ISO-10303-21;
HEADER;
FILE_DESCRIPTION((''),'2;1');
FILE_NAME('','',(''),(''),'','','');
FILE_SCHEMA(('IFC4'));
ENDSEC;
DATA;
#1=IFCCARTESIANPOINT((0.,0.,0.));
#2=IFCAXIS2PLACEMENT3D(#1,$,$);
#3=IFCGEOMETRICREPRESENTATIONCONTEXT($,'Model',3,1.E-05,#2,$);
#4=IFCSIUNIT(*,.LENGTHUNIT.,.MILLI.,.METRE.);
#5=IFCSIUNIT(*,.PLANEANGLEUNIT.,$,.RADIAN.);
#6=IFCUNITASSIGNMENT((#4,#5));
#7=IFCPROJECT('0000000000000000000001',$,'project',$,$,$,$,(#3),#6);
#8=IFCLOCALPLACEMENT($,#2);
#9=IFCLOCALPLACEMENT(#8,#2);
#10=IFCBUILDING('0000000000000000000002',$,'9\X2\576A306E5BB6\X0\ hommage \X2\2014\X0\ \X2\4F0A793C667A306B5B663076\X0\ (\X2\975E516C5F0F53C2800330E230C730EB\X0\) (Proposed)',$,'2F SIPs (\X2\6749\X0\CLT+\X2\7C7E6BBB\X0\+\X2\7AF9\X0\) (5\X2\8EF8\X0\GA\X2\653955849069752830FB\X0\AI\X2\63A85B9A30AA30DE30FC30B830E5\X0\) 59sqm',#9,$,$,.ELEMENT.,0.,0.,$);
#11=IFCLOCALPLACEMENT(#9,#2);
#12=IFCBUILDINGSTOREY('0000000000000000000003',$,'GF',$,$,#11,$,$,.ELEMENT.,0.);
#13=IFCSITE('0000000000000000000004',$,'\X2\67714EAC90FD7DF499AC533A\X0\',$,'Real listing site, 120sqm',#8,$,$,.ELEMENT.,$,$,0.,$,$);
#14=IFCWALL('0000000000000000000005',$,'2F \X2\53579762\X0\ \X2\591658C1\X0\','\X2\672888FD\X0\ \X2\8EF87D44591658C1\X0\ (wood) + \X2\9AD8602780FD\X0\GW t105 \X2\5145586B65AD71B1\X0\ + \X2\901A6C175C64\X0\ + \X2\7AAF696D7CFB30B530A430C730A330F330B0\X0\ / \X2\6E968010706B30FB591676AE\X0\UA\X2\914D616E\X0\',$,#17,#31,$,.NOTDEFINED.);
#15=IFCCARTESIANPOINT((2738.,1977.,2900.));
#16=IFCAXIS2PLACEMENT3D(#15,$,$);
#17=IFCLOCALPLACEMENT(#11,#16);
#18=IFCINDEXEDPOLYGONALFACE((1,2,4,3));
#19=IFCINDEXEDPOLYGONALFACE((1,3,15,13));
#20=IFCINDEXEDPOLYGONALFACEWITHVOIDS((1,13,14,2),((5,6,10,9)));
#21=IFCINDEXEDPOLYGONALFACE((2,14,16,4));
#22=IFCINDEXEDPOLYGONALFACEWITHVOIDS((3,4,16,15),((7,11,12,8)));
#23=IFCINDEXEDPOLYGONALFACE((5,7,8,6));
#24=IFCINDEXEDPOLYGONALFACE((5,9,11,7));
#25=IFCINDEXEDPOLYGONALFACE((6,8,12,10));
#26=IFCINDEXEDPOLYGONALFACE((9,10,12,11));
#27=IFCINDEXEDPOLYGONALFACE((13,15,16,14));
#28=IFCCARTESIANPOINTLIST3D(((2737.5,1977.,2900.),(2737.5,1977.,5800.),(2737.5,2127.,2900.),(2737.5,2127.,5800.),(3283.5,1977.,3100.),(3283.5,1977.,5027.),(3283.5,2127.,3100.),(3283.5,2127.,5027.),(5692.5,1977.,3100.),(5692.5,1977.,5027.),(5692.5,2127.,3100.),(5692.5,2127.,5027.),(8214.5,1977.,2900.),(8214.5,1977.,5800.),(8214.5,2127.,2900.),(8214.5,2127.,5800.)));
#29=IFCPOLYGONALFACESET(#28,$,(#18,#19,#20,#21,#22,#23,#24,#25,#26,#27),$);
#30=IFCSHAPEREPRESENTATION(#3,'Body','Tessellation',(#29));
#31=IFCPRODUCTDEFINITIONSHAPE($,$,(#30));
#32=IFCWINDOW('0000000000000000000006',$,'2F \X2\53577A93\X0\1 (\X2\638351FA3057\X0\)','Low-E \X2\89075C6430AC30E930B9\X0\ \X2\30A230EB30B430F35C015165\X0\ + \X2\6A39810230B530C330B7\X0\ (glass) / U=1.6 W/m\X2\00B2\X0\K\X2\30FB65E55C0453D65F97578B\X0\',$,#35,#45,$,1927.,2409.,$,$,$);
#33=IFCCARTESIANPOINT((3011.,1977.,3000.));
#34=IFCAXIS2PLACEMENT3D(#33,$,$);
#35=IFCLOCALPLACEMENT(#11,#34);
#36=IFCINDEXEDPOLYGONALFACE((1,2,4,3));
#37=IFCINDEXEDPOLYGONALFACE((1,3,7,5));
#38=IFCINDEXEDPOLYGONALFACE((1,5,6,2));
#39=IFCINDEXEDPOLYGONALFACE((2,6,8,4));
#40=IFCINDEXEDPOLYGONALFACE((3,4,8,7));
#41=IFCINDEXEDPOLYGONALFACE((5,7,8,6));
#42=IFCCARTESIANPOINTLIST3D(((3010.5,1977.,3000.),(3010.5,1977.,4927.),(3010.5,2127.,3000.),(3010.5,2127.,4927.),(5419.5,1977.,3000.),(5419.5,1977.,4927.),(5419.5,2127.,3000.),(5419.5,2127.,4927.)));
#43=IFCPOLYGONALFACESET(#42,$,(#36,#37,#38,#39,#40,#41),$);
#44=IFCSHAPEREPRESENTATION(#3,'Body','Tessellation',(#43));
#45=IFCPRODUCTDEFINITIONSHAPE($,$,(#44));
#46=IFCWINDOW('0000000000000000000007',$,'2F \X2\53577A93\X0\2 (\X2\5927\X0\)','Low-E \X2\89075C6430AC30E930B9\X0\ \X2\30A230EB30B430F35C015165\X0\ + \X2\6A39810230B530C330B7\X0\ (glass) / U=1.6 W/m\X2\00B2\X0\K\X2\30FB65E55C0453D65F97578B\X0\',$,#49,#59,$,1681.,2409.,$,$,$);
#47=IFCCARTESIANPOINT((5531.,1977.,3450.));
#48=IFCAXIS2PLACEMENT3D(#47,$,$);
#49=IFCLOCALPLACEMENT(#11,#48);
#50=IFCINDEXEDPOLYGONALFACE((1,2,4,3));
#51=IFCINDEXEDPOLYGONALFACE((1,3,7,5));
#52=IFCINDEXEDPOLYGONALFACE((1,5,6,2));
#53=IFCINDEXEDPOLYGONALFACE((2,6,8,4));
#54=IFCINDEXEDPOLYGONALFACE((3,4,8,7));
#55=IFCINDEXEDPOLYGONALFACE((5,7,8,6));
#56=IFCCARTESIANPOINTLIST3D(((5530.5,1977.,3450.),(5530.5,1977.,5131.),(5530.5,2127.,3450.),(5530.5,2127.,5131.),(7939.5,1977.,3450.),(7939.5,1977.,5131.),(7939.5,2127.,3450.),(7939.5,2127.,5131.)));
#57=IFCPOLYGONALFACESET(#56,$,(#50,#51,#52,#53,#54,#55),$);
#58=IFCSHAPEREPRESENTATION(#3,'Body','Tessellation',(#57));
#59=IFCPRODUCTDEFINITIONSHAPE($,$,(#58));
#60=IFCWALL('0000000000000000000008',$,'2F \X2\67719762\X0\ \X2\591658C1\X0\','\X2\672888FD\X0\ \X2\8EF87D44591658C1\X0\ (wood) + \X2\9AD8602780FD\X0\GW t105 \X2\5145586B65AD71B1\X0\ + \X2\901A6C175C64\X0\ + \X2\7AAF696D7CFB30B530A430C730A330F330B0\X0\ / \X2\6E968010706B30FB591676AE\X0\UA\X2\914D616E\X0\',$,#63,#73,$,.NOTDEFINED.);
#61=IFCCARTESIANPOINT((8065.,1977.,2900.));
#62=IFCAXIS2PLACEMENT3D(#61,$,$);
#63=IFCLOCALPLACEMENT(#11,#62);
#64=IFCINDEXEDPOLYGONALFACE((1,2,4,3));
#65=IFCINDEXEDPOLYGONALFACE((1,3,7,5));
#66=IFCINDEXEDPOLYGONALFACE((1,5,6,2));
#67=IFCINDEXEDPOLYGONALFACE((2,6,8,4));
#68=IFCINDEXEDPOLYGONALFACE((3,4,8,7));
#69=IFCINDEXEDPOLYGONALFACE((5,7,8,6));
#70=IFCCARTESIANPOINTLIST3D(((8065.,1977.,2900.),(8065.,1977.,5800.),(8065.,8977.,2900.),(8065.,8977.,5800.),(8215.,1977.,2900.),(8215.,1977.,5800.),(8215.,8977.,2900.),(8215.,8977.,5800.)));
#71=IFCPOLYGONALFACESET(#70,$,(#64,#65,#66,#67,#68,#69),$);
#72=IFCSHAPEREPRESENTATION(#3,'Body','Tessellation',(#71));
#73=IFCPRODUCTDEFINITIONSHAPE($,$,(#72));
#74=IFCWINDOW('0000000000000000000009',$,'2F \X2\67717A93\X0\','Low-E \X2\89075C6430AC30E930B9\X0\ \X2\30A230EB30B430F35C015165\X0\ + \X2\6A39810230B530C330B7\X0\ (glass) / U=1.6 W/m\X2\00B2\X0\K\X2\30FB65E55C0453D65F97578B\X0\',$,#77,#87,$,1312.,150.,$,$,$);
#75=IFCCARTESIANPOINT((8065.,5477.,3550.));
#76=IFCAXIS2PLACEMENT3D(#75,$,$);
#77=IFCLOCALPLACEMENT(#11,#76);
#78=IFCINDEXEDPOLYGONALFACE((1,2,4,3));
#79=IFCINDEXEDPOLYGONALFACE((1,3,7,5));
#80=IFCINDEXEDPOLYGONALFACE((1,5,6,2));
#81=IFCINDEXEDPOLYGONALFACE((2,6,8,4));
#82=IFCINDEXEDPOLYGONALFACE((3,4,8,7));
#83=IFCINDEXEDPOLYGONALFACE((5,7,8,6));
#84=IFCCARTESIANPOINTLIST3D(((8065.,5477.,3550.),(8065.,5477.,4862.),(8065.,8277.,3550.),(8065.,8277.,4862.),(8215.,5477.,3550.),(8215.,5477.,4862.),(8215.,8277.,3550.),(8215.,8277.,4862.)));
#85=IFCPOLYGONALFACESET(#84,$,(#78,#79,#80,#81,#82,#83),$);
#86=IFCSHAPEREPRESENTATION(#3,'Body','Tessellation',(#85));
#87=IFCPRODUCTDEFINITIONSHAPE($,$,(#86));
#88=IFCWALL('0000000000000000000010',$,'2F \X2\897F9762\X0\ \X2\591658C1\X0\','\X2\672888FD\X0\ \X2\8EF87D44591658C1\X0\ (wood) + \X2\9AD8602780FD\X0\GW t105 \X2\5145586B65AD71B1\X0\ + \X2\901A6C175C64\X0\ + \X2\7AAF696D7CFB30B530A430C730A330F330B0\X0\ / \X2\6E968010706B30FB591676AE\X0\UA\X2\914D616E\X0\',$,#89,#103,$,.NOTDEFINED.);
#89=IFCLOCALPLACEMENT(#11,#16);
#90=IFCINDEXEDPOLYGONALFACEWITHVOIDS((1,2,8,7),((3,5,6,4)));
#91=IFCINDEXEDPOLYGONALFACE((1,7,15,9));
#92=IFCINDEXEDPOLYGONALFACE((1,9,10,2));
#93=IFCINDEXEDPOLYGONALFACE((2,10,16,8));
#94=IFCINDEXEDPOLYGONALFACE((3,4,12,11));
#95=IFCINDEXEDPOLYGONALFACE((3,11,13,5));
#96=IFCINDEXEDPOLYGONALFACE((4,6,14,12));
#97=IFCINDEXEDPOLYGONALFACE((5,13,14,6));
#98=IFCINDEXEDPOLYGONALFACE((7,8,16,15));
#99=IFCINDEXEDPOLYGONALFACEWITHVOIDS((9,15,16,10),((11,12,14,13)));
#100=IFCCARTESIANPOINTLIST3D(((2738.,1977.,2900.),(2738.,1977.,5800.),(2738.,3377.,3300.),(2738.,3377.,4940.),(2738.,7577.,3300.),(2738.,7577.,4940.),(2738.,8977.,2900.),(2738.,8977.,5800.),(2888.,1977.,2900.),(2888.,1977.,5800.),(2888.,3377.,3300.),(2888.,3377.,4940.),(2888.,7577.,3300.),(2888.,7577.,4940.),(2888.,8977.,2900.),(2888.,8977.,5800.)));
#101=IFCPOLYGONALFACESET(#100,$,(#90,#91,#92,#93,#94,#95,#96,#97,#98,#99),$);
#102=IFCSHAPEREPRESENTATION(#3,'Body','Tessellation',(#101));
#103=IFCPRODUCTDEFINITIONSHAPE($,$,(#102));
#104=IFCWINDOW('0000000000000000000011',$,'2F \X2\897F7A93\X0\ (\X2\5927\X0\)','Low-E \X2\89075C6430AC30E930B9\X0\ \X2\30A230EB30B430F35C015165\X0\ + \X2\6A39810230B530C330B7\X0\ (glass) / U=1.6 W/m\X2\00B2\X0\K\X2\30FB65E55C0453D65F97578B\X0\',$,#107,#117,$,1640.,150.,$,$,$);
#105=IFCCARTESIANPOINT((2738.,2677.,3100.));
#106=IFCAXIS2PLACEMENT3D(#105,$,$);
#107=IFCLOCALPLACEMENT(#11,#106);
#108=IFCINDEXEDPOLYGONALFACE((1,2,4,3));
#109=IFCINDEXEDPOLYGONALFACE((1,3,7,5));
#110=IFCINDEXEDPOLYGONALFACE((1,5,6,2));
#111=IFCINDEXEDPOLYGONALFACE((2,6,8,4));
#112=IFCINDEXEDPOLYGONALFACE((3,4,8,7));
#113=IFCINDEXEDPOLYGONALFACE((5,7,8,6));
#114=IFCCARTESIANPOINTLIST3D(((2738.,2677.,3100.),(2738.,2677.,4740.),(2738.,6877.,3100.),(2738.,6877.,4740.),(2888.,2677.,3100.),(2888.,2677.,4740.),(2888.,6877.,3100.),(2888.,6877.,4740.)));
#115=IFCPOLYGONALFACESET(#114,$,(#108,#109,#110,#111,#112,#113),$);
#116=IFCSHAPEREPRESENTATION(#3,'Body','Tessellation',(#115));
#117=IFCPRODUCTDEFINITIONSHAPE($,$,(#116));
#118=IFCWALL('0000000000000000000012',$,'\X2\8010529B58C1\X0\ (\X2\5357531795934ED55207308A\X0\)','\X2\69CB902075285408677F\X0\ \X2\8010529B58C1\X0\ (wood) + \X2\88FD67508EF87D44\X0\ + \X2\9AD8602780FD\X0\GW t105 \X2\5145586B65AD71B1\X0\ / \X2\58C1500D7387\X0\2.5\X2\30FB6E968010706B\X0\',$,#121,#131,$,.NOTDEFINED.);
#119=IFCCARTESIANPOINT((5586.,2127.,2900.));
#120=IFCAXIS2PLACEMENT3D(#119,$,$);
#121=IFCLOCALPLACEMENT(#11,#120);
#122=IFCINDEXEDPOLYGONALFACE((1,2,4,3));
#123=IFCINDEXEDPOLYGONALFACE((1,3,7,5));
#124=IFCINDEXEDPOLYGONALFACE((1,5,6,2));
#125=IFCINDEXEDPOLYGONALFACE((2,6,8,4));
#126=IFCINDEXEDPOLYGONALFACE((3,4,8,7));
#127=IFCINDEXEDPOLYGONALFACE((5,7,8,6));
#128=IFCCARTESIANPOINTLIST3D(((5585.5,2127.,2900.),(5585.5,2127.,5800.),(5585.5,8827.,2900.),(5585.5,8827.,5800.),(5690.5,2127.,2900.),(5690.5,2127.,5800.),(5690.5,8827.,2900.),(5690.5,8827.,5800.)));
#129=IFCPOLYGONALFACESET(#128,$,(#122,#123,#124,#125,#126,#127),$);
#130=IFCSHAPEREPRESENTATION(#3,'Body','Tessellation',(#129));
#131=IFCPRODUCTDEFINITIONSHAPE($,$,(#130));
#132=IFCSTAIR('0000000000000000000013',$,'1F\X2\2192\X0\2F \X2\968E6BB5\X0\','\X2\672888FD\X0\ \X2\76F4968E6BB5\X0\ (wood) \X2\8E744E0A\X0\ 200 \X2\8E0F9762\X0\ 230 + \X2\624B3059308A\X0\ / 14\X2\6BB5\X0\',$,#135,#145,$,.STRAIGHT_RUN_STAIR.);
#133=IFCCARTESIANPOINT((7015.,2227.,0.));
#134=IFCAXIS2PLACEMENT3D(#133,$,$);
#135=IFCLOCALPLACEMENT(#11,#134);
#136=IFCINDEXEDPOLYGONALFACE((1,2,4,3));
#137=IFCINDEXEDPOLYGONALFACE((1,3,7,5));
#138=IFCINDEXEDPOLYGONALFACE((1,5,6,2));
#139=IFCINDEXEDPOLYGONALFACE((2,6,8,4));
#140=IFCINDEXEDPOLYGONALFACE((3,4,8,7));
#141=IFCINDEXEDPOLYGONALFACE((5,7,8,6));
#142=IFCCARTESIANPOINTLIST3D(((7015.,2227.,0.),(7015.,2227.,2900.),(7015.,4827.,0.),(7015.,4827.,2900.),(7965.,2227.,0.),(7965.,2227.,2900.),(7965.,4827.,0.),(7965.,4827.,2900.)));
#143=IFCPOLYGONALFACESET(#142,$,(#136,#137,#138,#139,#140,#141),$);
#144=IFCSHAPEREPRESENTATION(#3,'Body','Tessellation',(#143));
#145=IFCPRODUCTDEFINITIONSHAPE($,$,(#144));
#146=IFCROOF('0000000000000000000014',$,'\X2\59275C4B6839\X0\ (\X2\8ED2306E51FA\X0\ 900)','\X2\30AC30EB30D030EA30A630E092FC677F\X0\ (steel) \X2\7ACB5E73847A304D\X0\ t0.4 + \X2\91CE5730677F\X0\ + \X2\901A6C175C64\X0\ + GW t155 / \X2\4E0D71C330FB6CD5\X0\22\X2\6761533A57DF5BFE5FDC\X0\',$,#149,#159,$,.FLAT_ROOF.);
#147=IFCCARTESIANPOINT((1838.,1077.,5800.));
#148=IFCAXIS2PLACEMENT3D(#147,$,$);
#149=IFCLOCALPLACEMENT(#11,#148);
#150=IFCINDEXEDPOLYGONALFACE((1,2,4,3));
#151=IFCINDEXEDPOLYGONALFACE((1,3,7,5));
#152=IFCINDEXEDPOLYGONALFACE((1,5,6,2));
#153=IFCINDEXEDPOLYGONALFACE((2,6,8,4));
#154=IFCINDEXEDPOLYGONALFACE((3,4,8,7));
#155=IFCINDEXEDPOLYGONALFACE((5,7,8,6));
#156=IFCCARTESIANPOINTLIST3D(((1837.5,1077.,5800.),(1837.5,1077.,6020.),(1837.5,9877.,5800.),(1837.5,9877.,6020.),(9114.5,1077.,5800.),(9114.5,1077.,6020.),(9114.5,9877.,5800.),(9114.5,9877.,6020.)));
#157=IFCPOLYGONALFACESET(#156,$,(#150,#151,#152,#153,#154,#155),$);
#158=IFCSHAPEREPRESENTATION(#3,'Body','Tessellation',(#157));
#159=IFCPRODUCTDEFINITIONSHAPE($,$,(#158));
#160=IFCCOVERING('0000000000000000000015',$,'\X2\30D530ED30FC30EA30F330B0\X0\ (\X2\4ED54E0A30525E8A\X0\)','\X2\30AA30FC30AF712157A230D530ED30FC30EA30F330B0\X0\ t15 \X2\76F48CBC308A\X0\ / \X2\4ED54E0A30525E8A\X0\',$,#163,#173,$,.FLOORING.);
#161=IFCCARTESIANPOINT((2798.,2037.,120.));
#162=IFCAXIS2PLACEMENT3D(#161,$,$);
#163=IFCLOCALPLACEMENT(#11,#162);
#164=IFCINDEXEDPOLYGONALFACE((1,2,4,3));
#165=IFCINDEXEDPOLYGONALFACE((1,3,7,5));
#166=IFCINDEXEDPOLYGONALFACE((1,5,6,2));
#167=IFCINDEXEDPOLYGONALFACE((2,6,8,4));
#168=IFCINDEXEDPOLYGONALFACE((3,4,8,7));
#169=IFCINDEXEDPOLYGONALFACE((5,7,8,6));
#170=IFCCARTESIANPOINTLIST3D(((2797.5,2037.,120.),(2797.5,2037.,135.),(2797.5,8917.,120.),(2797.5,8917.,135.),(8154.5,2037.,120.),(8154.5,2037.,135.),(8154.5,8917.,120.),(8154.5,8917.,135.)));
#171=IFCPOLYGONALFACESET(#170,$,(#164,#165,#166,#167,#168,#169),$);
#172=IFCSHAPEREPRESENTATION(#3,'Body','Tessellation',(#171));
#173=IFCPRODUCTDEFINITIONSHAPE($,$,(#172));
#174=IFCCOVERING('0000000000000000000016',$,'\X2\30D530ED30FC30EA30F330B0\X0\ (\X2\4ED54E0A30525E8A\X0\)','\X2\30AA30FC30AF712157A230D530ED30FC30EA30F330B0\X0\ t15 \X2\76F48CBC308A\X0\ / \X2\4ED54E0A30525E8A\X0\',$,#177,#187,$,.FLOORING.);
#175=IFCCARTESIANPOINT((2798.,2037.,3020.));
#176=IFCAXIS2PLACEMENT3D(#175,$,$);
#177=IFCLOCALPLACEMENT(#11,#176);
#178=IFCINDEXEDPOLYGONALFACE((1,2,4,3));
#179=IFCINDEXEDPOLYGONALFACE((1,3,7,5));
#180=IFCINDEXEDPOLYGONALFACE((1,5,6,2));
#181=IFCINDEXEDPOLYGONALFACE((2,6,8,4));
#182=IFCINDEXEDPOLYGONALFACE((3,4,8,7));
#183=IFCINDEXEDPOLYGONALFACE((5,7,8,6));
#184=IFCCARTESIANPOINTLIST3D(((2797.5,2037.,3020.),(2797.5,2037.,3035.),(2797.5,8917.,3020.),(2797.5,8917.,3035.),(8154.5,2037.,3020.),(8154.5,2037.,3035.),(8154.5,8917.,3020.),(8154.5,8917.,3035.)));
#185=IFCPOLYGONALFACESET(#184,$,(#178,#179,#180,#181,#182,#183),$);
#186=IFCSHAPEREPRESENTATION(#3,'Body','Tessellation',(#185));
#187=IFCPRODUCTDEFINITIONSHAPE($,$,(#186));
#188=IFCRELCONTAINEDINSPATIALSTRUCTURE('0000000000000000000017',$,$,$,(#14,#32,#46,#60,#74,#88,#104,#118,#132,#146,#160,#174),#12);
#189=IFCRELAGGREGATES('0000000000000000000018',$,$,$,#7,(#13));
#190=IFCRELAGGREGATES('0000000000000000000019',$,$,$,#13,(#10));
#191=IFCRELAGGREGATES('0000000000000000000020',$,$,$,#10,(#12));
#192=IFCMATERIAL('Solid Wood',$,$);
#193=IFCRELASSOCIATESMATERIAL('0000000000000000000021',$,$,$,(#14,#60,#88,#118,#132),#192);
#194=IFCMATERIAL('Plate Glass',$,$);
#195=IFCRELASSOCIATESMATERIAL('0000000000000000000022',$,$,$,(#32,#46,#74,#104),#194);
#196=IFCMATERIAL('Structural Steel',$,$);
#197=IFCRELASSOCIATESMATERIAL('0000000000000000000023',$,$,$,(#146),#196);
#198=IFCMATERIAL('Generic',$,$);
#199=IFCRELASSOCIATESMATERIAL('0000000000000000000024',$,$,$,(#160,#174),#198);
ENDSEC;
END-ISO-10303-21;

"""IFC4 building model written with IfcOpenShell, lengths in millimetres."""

from ifc_helpers import new_model, si_unit, frame, frame_2d, origin, place, context, project, spatial, rectangle, extrude, material, element, fill, save


model = new_model("IFC4")

# Units and contexts
model_context = context("Model", 3, precision=1e-05, world=origin())
ifc_project = project(units=[si_unit("LENGTHUNIT", "METRE", prefix="MILLI"), si_unit("PLANEANGLEUNIT", "RADIAN")], contexts=[model_context])

# Site, building, storey
site_placement = place(None, origin())
site = spatial("IfcSite", under=ifc_project, at=site_placement, Name="東京都練馬区", ObjectType="Real listing site, 120sqm", CompositionType="ELEMENT", RefElevation=0.0)
building_placement = place(site_placement, origin())
building = spatial("IfcBuilding", under=site, at=building_placement, Name="9坪の家 hommage — 伊礼智に学ぶ (非公式参考モデル) (Proposed)", ObjectType="2F SIPs (杉CLT+籾殻+竹) (5軸GA改善適用・AI推定オマージュ) 59sqm", CompositionType="ELEMENT", ElevationOfRefHeight=0.0, ElevationOfTerrain=0.0)
storey_placement = place(building_placement, origin())
storey = spatial("IfcBuildingStorey", under=building, at=storey_placement, Name="GF", CompositionType="ELEMENT", Elevation=0.0)

# Shared definitions
ifc_material_1 = material(Name="Solid Wood")

# Shared definitions
ifc_material_2 = material(Name="Plate Glass")

# Wall, openings, windows
wall_1_placement = place(storey_placement, frame((2738.0, 1977.0, 2900.0)))
wall_1 = element("IfcWall", 1, at=wall_1_placement, inside=storey, material=ifc_material_1, Name="2F 南面 外壁", Description="木製 軸組外壁 (wood) + 高性能GW t105 充填断熱 + 通気層 + 窯業系サイディング / 準耐火・外皮UA配慮", PredefinedType="NOTDEFINED", context=model_context, shape_type="SweptSolid", body=[
    extrude(rectangle(XDim=5477.0, YDim=150.0, at=frame_2d((2738.0, 75.0))), frame((2738.0, 1977.0, 2900.0)), (0.0, 0.0, 1.0), 2900.0),
])
opening_1_placement = place(storey_placement, frame((3011.0, 1977.0, 3000.0)))
opening_1 = element("IfcOpeningElement", 2, at=opening_1_placement, cuts=wall_1, PredefinedType="NOTDEFINED", context=model_context, shape_type="SweptSolid", body=[
    extrude(rectangle(XDim=2409.0, YDim=150.0, at=frame_2d((1204.0, 75.0))), frame((3011.0, 1977.0, 3000.0)), (0.0, 0.0, 1.0), 1927.0),
])
opening_2_placement = place(storey_placement, frame((5531.0, 1977.0, 3450.0)))
opening_2 = element("IfcOpeningElement", 3, at=opening_2_placement, cuts=wall_1, PredefinedType="NOTDEFINED", context=model_context, shape_type="SweptSolid", body=[
    extrude(rectangle(XDim=2409.0, YDim=150.0, at=frame_2d((1204.0, 75.0))), frame((5531.0, 1977.0, 3450.0)), (0.0, 0.0, 1.0), 1681.0),
])
window_1_placement = place(storey_placement, frame((3011.0, 1977.0, 3000.0)))
window_1 = element("IfcWindow", 4, at=window_1_placement, inside=storey, material=ifc_material_2, Name="2F 南窓1 (掃出し)", Description="Low-E 複層ガラス アルゴン封入 + 樹脂サッシ (glass) / U=1.6 W/m²K・日射取得型", OverallHeight=1927.0, OverallWidth=2409.0, context=model_context, shape_type="SweptSolid", body=[
    extrude(rectangle(XDim=2409.0, YDim=150.0, at=frame_2d((1204.0, 75.0))), frame((3011.0, 1977.0, 3000.0)), (0.0, 0.0, 1.0), 1927.0),
])
fill(opening_1, window_1)
window_2_placement = place(storey_placement, frame((5531.0, 1977.0, 3450.0)))
window_2 = element("IfcWindow", 5, at=window_2_placement, inside=storey, material=ifc_material_2, Name="2F 南窓2 (大)", Description="Low-E 複層ガラス アルゴン封入 + 樹脂サッシ (glass) / U=1.6 W/m²K・日射取得型", OverallHeight=1681.0, OverallWidth=2409.0, context=model_context, shape_type="SweptSolid", body=[
    extrude(rectangle(XDim=2409.0, YDim=150.0, at=frame_2d((1204.0, 75.0))), frame((5531.0, 1977.0, 3450.0)), (0.0, 0.0, 1.0), 1681.0),
])
fill(opening_2, window_2)

# Walls, openings, windows
wall_2_placement = place(storey_placement, frame((8065.0, 1977.0, 2900.0)))
wall_2 = element("IfcWall", 6, at=wall_2_placement, inside=storey, material=ifc_material_1, Name="2F 東面 外壁", Description="木製 軸組外壁 (wood) + 高性能GW t105 充填断熱 + 通気層 + 窯業系サイディング / 準耐火・外皮UA配慮", PredefinedType="NOTDEFINED", context=model_context, shape_type="SweptSolid", body=[
    extrude(rectangle(XDim=150.0, YDim=7000.0, at=frame_2d((75.0, 3500.0))), frame((8065.0, 1977.0, 2900.0)), (0.0, 0.0, 1.0), 2900.0),
])
opening_3_placement = place(storey_placement, frame((8065.0, 5477.0, 3550.0)))
opening_3 = element("IfcOpeningElement", 7, at=opening_3_placement, cuts=wall_2, PredefinedType="NOTDEFINED", context=model_context, shape_type="SweptSolid", body=[
    extrude(rectangle(XDim=150.0, YDim=2800.0, at=frame_2d((75.0, 1400.0))), frame((8065.0, 5477.0, 3550.0)), (0.0, 0.0, 1.0), 1312.0),
])
window_3_placement = place(storey_placement, frame((8065.0, 5477.0, 3550.0)))
window_3 = element("IfcWindow", 8, at=window_3_placement, inside=storey, material=ifc_material_2, Name="2F 東窓", Description="Low-E 複層ガラス アルゴン封入 + 樹脂サッシ (glass) / U=1.6 W/m²K・日射取得型", OverallHeight=1312.0, OverallWidth=150.0, context=model_context, shape_type="SweptSolid", body=[
    extrude(rectangle(XDim=150.0, YDim=2800.0, at=frame_2d((75.0, 1400.0))), frame((8065.0, 5477.0, 3550.0)), (0.0, 0.0, 1.0), 1312.0),
])
fill(opening_3, window_3)
wall_3_placement = place(storey_placement, frame((2738.0, 1977.0, 2900.0)))
wall_3 = element("IfcWall", 9, at=wall_3_placement, inside=storey, material=ifc_material_1, Name="2F 西面 外壁", Description="木製 軸組外壁 (wood) + 高性能GW t105 充填断熱 + 通気層 + 窯業系サイディング / 準耐火・外皮UA配慮", PredefinedType="NOTDEFINED", context=model_context, shape_type="SweptSolid", body=[
    extrude(rectangle(XDim=150.0, YDim=7000.0, at=frame_2d((75.0, 3500.0))), frame((2738.0, 1977.0, 2900.0)), (0.0, 0.0, 1.0), 2900.0),
])
opening_4_placement = place(storey_placement, frame((2738.0, 2677.0, 3100.0)))
opening_4 = element("IfcOpeningElement", 10, at=opening_4_placement, cuts=wall_3, PredefinedType="NOTDEFINED", context=model_context, shape_type="SweptSolid", body=[
    extrude(rectangle(XDim=150.0, YDim=4200.0, at=frame_2d((75.0, 2100.0))), frame((2738.0, 2677.0, 3100.0)), (0.0, 0.0, 1.0), 1640.0),
])
window_4_placement = place(storey_placement, frame((2738.0, 2677.0, 3100.0)))
window_4 = element("IfcWindow", 11, at=window_4_placement, inside=storey, material=ifc_material_2, Name="2F 西窓 (大)", Description="Low-E 複層ガラス アルゴン封入 + 樹脂サッシ (glass) / U=1.6 W/m²K・日射取得型", OverallHeight=1640.0, OverallWidth=150.0, context=model_context, shape_type="SweptSolid", body=[
    extrude(rectangle(XDim=150.0, YDim=4200.0, at=frame_2d((75.0, 2100.0))), frame((2738.0, 2677.0, 3100.0)), (0.0, 0.0, 1.0), 1640.0),
])
fill(opening_4, window_4)

# Wall
wall_4_placement = place(storey_placement, frame((5586.0, 2127.0, 2900.0)))
element("IfcWall", 12, at=wall_4_placement, inside=storey, material=ifc_material_1, Name="耐力壁 (南北間仕切り)", Description="構造用合板 耐力壁 (wood) + 製材軸組 + 高性能GW t105 充填断熱 / 壁倍率2.5・準耐火", PredefinedType="NOTDEFINED", context=model_context, shape_type="SweptSolid", body=[
    extrude(rectangle(XDim=105.0, YDim=6700.0, at=frame_2d((52.0, 3350.0))), frame((5586.0, 2127.0, 2900.0)), (0.0, 0.0, 1.0), 2900.0),
])

# Stair
stair_placement = place(storey_placement, frame((7015.0, 2227.0, 0.0)))
element("IfcStair", 13, at=stair_placement, inside=storey, material=ifc_material_1, Name="1F→2F 階段", Description="木製 直階段 (wood) 蹴上 200 踏面 230 + 手すり / 14段", PredefinedType="STRAIGHT_RUN_STAIR", context=model_context, shape_type="SweptSolid", body=[
    extrude(rectangle(XDim=950.0, YDim=2600.0, at=frame_2d((475.0, 1300.0))), frame((7015.0, 2227.0, 0.0)), (0.0, 0.0, 1.0), 2900.0),
])

# Roof
ifc_material_3 = material(Name="Structural Steel")
roof_placement = place(storey_placement, frame((1838.0, 1077.0, 5800.0)))
element("IfcRoof", 14, at=roof_placement, inside=storey, material=ifc_material_3, Name="大屋根 (軒の出 900)", Description="ガルバリウム鋼板 (steel) 立平葺き t0.4 + 野地板 + 通気層 + GW t155 / 不燃・法22条区域対応", PredefinedType="FLAT_ROOF", context=model_context, shape_type="SweptSolid", body=[
    extrude(rectangle(XDim=7277.0, YDim=8800.0, at=frame_2d((3638.0, 4400.0))), frame((1838.0, 1077.0, 5800.0)), (0.0, 0.0, 1.0), 220.0),
])

# Coverings
ifc_material_4 = material(Name="Generic")
covering_1_placement = place(storey_placement, frame((2798.0, 2037.0, 120.0)))
element("IfcCovering", 15, at=covering_1_placement, inside=storey, material=ifc_material_4, Name="フローリング (仕上げ床)", Description="オーク無垢フローリング t15 直貼り / 仕上げ床", PredefinedType="FLOORING", context=model_context, shape_type="SweptSolid", body=[
    extrude(rectangle(XDim=5357.0, YDim=6880.0, at=frame_2d((2678.0, 3440.0))), frame((2798.0, 2037.0, 120.0)), (0.0, 0.0, 1.0), 15.0),
])
covering_2_placement = place(storey_placement, frame((2798.0, 2037.0, 3020.0)))
element("IfcCovering", 16, at=covering_2_placement, inside=storey, material=ifc_material_4, Name="フローリング (仕上げ床)", Description="オーク無垢フローリング t15 直貼り / 仕上げ床", PredefinedType="FLOORING", context=model_context, shape_type="SweptSolid", body=[
    extrude(rectangle(XDim=5357.0, YDim=6880.0, at=frame_2d((2678.0, 3440.0))), frame((2798.0, 2037.0, 3020.0)), (0.0, 0.0, 1.0), 15.0),
])

save(model, "model.ifc")
